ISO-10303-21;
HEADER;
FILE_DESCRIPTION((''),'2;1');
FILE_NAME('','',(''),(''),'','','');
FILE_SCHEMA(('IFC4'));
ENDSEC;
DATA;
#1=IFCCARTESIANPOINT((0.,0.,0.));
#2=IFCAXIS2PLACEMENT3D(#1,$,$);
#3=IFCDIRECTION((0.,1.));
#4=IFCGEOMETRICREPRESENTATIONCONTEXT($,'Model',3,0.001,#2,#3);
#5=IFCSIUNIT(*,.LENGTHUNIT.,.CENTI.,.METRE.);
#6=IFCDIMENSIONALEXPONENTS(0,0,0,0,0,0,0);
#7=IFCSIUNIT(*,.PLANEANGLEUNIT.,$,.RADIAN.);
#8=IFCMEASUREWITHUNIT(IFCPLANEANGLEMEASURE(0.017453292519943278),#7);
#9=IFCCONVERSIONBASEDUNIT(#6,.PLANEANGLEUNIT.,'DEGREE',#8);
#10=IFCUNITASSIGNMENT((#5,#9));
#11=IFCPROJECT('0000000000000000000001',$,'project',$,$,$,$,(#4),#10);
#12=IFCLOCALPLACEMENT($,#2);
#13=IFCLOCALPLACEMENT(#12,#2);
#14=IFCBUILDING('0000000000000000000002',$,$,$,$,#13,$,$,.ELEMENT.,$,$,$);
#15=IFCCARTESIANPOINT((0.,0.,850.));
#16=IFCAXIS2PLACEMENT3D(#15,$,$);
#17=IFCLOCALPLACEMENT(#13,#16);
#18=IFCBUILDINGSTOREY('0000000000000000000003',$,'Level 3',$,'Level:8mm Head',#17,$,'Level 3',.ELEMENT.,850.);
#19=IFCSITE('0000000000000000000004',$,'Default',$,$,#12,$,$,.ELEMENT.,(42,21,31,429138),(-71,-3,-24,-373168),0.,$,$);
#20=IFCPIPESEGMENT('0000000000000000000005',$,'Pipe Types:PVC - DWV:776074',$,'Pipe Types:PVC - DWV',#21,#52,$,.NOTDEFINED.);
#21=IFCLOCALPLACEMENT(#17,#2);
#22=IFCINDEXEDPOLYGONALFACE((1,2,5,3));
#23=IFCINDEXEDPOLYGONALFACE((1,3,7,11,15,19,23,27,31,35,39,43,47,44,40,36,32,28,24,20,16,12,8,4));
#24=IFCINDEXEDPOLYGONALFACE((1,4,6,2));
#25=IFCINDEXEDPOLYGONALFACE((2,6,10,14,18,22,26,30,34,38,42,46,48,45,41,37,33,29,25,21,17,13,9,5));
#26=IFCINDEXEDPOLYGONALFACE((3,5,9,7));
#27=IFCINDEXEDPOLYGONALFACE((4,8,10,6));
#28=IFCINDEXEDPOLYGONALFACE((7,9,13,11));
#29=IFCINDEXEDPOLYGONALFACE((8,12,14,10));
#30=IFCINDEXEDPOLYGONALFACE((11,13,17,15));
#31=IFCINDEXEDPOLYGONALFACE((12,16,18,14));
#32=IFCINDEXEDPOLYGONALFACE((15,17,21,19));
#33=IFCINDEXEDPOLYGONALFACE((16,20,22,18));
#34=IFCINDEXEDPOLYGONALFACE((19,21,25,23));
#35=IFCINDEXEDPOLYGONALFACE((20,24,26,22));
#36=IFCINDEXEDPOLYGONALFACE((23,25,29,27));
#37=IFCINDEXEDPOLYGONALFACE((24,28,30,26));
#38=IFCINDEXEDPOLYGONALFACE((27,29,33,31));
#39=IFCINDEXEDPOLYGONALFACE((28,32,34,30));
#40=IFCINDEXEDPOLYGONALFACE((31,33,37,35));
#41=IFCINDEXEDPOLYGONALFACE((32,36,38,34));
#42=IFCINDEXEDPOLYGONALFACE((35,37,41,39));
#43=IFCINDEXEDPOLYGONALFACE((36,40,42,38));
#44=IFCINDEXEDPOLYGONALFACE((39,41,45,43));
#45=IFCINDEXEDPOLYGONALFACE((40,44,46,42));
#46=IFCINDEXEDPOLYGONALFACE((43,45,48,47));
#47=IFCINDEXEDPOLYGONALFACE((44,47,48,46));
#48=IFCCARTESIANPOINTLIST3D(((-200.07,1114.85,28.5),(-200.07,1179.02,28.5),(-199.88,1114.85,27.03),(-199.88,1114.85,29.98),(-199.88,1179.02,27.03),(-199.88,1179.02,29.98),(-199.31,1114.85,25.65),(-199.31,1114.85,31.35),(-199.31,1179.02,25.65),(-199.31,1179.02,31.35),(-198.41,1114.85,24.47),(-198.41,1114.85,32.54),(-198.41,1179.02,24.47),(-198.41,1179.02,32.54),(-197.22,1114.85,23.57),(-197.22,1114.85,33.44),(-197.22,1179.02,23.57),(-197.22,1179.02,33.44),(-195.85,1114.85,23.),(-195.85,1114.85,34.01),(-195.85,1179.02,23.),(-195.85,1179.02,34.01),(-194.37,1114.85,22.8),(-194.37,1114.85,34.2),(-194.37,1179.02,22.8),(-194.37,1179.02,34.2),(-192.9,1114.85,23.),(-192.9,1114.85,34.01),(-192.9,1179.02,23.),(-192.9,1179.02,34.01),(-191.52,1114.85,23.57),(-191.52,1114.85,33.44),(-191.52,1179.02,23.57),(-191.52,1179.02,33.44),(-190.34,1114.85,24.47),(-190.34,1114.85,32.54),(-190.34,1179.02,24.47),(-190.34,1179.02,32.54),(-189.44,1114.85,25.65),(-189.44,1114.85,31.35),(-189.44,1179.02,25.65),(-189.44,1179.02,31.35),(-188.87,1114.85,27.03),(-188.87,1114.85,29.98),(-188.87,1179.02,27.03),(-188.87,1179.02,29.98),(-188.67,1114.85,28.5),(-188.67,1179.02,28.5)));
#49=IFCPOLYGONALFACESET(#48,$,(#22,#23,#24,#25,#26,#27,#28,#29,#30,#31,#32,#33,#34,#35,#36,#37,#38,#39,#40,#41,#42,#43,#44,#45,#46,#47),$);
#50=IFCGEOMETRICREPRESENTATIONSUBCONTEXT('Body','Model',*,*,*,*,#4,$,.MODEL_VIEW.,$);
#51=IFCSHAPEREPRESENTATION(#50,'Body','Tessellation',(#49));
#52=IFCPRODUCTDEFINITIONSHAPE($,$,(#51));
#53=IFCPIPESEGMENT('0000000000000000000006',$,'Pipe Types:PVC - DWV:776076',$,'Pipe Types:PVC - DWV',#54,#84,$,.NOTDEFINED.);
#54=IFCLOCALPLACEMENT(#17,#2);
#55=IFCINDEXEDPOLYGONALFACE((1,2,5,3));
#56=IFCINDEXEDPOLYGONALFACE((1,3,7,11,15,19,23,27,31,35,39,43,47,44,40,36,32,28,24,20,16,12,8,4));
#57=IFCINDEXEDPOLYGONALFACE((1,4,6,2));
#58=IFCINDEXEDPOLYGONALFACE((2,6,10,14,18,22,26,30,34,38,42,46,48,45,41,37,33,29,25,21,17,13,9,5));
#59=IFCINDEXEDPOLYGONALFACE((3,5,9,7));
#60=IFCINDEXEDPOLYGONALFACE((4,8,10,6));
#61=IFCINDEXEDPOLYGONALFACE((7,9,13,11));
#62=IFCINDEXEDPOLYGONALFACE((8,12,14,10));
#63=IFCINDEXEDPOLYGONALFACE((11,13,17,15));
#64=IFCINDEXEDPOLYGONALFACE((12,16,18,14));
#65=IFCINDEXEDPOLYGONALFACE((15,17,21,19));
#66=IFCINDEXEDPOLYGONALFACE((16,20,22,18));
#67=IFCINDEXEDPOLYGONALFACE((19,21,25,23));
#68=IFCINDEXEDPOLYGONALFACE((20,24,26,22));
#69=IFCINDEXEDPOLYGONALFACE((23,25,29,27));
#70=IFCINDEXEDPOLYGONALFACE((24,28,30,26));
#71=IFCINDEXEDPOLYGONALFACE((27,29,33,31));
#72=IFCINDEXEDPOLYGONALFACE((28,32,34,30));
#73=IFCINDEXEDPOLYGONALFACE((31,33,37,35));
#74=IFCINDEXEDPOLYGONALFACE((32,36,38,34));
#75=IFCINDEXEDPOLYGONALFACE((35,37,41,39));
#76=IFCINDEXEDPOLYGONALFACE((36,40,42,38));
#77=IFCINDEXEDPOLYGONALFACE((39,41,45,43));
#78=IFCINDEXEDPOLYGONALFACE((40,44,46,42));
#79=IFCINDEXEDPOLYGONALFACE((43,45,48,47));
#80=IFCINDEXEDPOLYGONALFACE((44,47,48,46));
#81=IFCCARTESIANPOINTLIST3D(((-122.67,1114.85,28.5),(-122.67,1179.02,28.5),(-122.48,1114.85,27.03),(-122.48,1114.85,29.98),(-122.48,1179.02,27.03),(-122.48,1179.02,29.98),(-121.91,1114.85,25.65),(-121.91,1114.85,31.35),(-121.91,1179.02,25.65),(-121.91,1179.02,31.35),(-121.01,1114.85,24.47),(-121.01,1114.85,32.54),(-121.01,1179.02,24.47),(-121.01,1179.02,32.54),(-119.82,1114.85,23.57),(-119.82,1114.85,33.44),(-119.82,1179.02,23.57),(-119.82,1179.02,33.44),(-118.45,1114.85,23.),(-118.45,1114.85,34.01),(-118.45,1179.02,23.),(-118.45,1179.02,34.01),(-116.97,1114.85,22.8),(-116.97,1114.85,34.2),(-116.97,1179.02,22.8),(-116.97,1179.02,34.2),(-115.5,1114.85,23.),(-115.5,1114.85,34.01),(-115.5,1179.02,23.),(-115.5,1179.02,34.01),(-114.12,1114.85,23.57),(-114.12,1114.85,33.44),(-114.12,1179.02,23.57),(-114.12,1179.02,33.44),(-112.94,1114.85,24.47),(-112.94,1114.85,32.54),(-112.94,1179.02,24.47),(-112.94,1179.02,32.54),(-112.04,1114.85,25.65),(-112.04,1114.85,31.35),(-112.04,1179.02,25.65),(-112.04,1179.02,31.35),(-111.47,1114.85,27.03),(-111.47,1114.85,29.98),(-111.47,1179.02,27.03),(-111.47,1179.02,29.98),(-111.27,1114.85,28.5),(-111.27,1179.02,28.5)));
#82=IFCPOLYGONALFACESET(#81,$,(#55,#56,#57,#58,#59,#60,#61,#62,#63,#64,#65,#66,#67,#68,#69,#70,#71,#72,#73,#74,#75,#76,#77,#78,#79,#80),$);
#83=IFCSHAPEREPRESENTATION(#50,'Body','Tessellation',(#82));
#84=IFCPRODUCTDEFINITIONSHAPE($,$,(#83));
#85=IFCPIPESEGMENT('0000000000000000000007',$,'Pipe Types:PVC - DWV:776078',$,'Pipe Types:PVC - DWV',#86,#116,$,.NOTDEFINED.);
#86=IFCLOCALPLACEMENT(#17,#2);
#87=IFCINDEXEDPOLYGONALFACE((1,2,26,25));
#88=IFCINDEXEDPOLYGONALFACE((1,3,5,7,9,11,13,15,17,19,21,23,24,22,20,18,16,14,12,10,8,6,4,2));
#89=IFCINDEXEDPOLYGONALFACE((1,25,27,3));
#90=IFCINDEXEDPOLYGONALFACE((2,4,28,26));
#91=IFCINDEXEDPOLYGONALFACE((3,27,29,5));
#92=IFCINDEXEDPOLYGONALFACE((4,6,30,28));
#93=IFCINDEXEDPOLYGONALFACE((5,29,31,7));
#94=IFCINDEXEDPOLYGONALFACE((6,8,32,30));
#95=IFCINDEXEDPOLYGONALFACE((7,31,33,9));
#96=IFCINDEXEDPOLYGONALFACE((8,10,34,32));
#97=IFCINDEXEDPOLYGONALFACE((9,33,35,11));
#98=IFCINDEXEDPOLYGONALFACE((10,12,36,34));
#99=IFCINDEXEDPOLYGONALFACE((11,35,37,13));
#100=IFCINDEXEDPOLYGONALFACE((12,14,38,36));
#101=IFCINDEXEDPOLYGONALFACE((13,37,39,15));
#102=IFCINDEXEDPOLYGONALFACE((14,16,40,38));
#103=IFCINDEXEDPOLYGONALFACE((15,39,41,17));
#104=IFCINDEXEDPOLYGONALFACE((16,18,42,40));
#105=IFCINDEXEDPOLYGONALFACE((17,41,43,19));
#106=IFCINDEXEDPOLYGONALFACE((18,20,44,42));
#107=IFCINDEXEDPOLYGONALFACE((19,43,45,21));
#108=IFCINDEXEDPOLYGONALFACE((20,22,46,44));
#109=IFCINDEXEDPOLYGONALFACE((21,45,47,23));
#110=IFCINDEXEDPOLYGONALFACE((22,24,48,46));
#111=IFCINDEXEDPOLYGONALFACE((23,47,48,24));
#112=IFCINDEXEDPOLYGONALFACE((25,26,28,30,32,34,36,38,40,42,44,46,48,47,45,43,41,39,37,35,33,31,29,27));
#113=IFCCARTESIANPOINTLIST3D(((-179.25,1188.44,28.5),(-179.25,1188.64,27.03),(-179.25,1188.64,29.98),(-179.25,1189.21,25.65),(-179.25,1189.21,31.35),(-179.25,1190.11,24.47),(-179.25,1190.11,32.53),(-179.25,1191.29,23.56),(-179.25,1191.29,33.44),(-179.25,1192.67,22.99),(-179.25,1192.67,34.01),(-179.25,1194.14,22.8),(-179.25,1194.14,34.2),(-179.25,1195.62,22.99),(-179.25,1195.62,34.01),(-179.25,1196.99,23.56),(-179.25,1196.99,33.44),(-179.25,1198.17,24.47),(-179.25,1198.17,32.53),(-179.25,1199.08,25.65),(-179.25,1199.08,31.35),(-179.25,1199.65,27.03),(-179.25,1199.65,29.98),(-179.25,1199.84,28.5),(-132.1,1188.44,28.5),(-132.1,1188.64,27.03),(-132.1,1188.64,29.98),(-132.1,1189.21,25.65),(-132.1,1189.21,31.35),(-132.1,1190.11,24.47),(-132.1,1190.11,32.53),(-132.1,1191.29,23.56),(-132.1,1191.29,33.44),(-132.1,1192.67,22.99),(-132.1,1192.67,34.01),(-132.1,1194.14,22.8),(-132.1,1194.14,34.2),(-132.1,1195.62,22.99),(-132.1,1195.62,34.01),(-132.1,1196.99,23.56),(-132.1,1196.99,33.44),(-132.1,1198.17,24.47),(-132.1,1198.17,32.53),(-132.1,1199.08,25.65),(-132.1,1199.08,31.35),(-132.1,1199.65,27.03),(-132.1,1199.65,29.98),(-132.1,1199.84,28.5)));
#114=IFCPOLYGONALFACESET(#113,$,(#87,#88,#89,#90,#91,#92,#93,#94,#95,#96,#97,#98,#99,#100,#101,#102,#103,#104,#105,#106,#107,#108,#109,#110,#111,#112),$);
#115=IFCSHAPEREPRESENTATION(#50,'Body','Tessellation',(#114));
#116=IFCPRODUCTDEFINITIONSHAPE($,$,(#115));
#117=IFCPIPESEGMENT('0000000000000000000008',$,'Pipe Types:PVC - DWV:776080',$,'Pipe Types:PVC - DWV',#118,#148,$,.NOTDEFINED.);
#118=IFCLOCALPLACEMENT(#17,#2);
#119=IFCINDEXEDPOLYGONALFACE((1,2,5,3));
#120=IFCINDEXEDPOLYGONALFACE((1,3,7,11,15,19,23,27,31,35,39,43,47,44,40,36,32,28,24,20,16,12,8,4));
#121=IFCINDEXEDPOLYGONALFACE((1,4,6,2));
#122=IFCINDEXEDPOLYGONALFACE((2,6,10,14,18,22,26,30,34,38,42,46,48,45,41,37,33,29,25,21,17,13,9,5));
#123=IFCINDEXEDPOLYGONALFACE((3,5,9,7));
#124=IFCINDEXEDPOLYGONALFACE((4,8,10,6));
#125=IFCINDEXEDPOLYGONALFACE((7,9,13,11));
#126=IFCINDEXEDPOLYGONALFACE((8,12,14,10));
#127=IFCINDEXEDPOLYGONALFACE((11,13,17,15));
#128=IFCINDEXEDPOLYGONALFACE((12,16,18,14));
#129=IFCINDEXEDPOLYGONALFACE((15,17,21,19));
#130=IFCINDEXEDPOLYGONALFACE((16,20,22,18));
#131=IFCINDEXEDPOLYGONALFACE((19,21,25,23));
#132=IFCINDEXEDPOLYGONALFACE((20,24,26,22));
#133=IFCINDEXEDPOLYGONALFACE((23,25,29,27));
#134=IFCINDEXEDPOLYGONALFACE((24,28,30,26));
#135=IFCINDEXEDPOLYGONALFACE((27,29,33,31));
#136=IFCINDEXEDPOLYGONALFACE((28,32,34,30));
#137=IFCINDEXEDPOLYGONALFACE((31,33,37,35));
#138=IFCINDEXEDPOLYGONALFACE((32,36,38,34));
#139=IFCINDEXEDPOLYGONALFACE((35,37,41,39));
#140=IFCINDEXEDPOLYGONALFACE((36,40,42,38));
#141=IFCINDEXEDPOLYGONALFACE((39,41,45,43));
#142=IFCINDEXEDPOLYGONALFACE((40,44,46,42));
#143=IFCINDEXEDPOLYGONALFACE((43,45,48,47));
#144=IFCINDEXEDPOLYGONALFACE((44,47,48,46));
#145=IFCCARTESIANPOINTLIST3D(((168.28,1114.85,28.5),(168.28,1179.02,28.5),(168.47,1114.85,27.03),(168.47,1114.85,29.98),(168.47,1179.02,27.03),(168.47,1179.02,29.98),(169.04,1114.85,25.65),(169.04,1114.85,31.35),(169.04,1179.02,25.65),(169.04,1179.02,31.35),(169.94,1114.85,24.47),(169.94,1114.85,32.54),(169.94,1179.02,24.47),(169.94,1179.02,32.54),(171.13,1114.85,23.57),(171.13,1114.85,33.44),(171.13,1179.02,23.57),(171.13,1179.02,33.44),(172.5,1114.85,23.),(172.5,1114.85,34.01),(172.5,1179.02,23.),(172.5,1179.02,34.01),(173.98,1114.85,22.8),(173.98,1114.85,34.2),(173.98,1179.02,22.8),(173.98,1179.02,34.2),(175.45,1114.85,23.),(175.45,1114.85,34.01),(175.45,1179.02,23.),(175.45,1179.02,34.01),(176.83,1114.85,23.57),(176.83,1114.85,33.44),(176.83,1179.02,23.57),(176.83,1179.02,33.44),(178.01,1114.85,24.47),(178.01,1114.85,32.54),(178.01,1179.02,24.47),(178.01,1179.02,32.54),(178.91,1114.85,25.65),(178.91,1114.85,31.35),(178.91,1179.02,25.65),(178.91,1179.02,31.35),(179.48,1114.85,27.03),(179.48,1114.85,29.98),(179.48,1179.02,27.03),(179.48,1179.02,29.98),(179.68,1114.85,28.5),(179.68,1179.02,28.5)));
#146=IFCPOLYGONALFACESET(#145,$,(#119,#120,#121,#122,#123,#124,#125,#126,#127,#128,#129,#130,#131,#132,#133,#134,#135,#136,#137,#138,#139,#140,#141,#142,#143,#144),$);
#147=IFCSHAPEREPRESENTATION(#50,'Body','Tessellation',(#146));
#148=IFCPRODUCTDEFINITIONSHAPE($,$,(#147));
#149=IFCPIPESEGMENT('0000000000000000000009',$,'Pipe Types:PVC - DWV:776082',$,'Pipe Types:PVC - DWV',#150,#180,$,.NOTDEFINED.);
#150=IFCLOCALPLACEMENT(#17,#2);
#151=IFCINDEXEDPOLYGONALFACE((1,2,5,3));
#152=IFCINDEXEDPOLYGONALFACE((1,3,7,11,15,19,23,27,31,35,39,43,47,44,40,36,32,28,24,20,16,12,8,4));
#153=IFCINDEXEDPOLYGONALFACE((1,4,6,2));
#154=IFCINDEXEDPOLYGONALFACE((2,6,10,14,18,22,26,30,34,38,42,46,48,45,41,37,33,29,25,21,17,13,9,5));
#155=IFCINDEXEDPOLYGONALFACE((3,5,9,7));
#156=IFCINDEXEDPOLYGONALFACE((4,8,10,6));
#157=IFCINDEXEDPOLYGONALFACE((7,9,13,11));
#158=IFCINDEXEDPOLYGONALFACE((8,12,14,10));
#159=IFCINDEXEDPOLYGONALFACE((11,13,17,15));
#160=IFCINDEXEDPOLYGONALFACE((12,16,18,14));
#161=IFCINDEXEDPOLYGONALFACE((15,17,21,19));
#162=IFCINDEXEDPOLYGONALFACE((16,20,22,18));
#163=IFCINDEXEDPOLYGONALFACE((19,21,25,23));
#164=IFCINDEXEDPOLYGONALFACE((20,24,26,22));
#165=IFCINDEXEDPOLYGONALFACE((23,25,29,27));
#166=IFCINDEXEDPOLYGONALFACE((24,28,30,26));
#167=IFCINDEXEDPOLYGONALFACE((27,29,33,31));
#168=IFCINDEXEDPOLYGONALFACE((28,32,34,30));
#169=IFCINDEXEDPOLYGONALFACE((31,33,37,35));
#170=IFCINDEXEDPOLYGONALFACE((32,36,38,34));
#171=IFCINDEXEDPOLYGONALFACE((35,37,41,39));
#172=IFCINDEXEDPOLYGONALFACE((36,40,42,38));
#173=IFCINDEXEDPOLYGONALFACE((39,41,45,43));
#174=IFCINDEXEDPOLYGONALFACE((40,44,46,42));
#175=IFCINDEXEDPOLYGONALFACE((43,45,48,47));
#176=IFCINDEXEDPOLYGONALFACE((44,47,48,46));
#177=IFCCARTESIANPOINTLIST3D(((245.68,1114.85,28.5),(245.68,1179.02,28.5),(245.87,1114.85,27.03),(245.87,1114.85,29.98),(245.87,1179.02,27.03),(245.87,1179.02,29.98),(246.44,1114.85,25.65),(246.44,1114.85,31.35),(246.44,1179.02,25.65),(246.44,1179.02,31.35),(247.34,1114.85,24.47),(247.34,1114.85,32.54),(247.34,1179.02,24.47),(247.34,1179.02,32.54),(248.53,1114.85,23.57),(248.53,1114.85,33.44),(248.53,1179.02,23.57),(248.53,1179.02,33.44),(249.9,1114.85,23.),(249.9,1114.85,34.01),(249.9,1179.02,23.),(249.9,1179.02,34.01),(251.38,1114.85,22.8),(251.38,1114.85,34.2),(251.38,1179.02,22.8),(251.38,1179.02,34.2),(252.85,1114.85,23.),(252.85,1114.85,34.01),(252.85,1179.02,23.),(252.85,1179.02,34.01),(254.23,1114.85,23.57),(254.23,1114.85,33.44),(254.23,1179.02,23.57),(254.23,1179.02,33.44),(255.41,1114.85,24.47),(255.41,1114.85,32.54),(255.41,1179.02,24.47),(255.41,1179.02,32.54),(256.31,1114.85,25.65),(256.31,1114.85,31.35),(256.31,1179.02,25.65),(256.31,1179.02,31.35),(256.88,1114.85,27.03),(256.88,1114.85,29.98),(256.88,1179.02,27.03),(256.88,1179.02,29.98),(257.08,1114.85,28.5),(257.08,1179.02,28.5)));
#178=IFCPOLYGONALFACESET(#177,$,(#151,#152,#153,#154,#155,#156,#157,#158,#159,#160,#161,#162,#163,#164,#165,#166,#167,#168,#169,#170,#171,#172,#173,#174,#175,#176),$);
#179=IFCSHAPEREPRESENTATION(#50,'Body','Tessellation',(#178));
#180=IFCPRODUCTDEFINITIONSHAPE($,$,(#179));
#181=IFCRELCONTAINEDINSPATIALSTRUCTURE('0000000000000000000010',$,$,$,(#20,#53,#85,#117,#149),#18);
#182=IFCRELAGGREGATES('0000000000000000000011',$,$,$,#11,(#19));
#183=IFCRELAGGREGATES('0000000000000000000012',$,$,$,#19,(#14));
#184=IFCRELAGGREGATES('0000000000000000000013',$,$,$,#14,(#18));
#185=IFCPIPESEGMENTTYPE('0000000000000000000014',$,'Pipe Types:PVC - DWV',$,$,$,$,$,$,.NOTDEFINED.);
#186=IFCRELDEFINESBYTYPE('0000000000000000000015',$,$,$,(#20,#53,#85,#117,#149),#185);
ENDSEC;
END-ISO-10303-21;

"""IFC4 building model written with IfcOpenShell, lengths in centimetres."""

from ifc_helpers import new_model, entity, si_unit, converted_unit, direction, frame, origin, place, context, subcontext, project, spatial, arc, indexed_curve, outline, extrude, type_object, element, save


model = new_model("IFC4")

# Units and contexts
model_context = context("Model", 3, precision=0.001, world=origin(), true_north=direction((0.0, 1.0)))
body_context = subcontext(model_context, "Body", "Model", "MODEL_VIEW")
ifc_project = project(units=[si_unit("LENGTHUNIT", "METRE", prefix="CENTI"), converted_unit("PLANEANGLEUNIT", "DEGREE", entity("IfcPlaneAngleMeasure", 0.017453292519943278), si_unit("PLANEANGLEUNIT", "RADIAN"), dimensions=[0, 0, 0, 0, 0, 0, 0])], contexts=[model_context])

# Site, building, storey
site_placement = place(None, origin())
site = spatial("IfcSite", under=ifc_project, at=site_placement, Name="Default", CompositionType="ELEMENT", RefLatitude=(42, 21, 31, 429138), RefLongitude=(-71, -3, -24, -373168), RefElevation=0.0)
building_placement = place(site_placement, origin())
building = spatial("IfcBuilding", under=site, at=building_placement, CompositionType="ELEMENT")
storey_placement = place(building_placement, frame((0.0, 0.0, 850.0)))
storey = spatial("IfcBuildingStorey", under=building, at=storey_placement, Name="Level 3", ObjectType="Level:8mm Head", LongName="Level 3", CompositionType="ELEMENT", Elevation=850.0)

# Pipe segments
pipe_segment_type = type_object("IfcPipeSegmentType", Name="Pipe Types:PVC - DWV", PredefinedType="NOTDEFINED")
pipe_segment_1_placement = place(storey_placement, origin())
element("IfcPipeSegment", 1, at=pipe_segment_1_placement, inside=storey, type_object=pipe_segment_type, Name="Pipe Types:PVC - DWV:776074", ObjectType="Pipe Types:PVC - DWV", PredefinedType="NOTDEFINED", context=body_context, shape_type="SweptSolid", body=[
    extrude(outline(indexed_curve([(5.7, 0.0), (4.03, 4.03), (0.0, 5.7), (-4.03, 4.03), (-5.7, 0.0), (-4.03, -4.03), (0.0, -5.7), (4.03, -4.03)], segments=[arc(1, 2, 3), arc(3, 4, 5), arc(5, 6, 7), arc(7, 8, 1)], self_intersect=False)), frame((-194.37, 1114.85, 28.5), z_axis=(0.0, 1.0, 0.0), x_axis=(-1.0, 0.0, 0.0)), (0.0, 0.0, 1.0), 64.18),
])
pipe_segment_2_placement = place(storey_placement, origin())
element("IfcPipeSegment", 2, at=pipe_segment_2_placement, inside=storey, type_object=pipe_segment_type, Name="Pipe Types:PVC - DWV:776076", ObjectType="Pipe Types:PVC - DWV", PredefinedType="NOTDEFINED", context=body_context, shape_type="SweptSolid", body=[
    extrude(outline(indexed_curve([(5.7, 0.0), (4.03, 4.03), (0.0, 5.7), (-4.03, 4.03), (-5.7, 0.0), (-4.03, -4.03), (0.0, -5.7), (4.03, -4.03)], segments=[arc(1, 2, 3), arc(3, 4, 5), arc(5, 6, 7), arc(7, 8, 1)], self_intersect=False)), frame((-116.97, 1114.85, 28.5), z_axis=(0.0, 1.0, 0.0), x_axis=(-1.0, 0.0, 0.0)), (0.0, 0.0, 1.0), 64.18),
])
pipe_segment_3_placement = place(storey_placement, origin())
element("IfcPipeSegment", 3, at=pipe_segment_3_placement, inside=storey, type_object=pipe_segment_type, Name="Pipe Types:PVC - DWV:776078", ObjectType="Pipe Types:PVC - DWV", PredefinedType="NOTDEFINED", context=body_context, shape_type="SweptSolid", body=[
    extrude(outline(indexed_curve([(5.7, 0.0), (4.03, 4.03), (0.0, 5.7), (-4.03, 4.03), (-5.7, 0.0), (-4.03, -4.03), (0.0, -5.7), (4.03, -4.03)], segments=[arc(1, 2, 3), arc(3, 4, 5), arc(5, 6, 7), arc(7, 8, 1)], self_intersect=False)), frame((-179.25, 1194.14, 28.5), z_axis=(1.0, 0.0, 0.0), x_axis=(0.0, 1.0, 0.0)), (0.0, 0.0, 1.0), 47.16),
])
pipe_segment_4_placement = place(storey_placement, origin())
element("IfcPipeSegment", 4, at=pipe_segment_4_placement, inside=storey, type_object=pipe_segment_type, Name="Pipe Types:PVC - DWV:776080", ObjectType="Pipe Types:PVC - DWV", PredefinedType="NOTDEFINED", context=body_context, shape_type="SweptSolid", body=[
    extrude(outline(indexed_curve([(5.7, 0.0), (4.03, 4.03), (0.0, 5.7), (-4.03, 4.03), (-5.7, 0.0), (-4.03, -4.03), (0.0, -5.7), (4.03, -4.03)], segments=[arc(1, 2, 3), arc(3, 4, 5), arc(5, 6, 7), arc(7, 8, 1)], self_intersect=False)), frame((173.98, 1114.85, 28.5), z_axis=(0.0, 1.0, 0.0), x_axis=(-1.0, 0.0, 0.0)), (0.0, 0.0, 1.0), 64.18),
])
pipe_segment_5_placement = place(storey_placement, origin())
element("IfcPipeSegment", 5, at=pipe_segment_5_placement, inside=storey, type_object=pipe_segment_type, Name="Pipe Types:PVC - DWV:776082", ObjectType="Pipe Types:PVC - DWV", PredefinedType="NOTDEFINED", context=body_context, shape_type="SweptSolid", body=[
    extrude(outline(indexed_curve([(5.7, 0.0), (4.03, 4.03), (0.0, 5.7), (-4.03, 4.03), (-5.7, 0.0), (-4.03, -4.03), (0.0, -5.7), (4.03, -4.03)], segments=[arc(1, 2, 3), arc(3, 4, 5), arc(5, 6, 7), arc(7, 8, 1)], self_intersect=False)), frame((251.38, 1114.85, 28.5), z_axis=(0.0, 1.0, 0.0), x_axis=(-1.0, 0.0, 0.0)), (0.0, 0.0, 1.0), 64.18),
])

save(model, "model.ifc")
